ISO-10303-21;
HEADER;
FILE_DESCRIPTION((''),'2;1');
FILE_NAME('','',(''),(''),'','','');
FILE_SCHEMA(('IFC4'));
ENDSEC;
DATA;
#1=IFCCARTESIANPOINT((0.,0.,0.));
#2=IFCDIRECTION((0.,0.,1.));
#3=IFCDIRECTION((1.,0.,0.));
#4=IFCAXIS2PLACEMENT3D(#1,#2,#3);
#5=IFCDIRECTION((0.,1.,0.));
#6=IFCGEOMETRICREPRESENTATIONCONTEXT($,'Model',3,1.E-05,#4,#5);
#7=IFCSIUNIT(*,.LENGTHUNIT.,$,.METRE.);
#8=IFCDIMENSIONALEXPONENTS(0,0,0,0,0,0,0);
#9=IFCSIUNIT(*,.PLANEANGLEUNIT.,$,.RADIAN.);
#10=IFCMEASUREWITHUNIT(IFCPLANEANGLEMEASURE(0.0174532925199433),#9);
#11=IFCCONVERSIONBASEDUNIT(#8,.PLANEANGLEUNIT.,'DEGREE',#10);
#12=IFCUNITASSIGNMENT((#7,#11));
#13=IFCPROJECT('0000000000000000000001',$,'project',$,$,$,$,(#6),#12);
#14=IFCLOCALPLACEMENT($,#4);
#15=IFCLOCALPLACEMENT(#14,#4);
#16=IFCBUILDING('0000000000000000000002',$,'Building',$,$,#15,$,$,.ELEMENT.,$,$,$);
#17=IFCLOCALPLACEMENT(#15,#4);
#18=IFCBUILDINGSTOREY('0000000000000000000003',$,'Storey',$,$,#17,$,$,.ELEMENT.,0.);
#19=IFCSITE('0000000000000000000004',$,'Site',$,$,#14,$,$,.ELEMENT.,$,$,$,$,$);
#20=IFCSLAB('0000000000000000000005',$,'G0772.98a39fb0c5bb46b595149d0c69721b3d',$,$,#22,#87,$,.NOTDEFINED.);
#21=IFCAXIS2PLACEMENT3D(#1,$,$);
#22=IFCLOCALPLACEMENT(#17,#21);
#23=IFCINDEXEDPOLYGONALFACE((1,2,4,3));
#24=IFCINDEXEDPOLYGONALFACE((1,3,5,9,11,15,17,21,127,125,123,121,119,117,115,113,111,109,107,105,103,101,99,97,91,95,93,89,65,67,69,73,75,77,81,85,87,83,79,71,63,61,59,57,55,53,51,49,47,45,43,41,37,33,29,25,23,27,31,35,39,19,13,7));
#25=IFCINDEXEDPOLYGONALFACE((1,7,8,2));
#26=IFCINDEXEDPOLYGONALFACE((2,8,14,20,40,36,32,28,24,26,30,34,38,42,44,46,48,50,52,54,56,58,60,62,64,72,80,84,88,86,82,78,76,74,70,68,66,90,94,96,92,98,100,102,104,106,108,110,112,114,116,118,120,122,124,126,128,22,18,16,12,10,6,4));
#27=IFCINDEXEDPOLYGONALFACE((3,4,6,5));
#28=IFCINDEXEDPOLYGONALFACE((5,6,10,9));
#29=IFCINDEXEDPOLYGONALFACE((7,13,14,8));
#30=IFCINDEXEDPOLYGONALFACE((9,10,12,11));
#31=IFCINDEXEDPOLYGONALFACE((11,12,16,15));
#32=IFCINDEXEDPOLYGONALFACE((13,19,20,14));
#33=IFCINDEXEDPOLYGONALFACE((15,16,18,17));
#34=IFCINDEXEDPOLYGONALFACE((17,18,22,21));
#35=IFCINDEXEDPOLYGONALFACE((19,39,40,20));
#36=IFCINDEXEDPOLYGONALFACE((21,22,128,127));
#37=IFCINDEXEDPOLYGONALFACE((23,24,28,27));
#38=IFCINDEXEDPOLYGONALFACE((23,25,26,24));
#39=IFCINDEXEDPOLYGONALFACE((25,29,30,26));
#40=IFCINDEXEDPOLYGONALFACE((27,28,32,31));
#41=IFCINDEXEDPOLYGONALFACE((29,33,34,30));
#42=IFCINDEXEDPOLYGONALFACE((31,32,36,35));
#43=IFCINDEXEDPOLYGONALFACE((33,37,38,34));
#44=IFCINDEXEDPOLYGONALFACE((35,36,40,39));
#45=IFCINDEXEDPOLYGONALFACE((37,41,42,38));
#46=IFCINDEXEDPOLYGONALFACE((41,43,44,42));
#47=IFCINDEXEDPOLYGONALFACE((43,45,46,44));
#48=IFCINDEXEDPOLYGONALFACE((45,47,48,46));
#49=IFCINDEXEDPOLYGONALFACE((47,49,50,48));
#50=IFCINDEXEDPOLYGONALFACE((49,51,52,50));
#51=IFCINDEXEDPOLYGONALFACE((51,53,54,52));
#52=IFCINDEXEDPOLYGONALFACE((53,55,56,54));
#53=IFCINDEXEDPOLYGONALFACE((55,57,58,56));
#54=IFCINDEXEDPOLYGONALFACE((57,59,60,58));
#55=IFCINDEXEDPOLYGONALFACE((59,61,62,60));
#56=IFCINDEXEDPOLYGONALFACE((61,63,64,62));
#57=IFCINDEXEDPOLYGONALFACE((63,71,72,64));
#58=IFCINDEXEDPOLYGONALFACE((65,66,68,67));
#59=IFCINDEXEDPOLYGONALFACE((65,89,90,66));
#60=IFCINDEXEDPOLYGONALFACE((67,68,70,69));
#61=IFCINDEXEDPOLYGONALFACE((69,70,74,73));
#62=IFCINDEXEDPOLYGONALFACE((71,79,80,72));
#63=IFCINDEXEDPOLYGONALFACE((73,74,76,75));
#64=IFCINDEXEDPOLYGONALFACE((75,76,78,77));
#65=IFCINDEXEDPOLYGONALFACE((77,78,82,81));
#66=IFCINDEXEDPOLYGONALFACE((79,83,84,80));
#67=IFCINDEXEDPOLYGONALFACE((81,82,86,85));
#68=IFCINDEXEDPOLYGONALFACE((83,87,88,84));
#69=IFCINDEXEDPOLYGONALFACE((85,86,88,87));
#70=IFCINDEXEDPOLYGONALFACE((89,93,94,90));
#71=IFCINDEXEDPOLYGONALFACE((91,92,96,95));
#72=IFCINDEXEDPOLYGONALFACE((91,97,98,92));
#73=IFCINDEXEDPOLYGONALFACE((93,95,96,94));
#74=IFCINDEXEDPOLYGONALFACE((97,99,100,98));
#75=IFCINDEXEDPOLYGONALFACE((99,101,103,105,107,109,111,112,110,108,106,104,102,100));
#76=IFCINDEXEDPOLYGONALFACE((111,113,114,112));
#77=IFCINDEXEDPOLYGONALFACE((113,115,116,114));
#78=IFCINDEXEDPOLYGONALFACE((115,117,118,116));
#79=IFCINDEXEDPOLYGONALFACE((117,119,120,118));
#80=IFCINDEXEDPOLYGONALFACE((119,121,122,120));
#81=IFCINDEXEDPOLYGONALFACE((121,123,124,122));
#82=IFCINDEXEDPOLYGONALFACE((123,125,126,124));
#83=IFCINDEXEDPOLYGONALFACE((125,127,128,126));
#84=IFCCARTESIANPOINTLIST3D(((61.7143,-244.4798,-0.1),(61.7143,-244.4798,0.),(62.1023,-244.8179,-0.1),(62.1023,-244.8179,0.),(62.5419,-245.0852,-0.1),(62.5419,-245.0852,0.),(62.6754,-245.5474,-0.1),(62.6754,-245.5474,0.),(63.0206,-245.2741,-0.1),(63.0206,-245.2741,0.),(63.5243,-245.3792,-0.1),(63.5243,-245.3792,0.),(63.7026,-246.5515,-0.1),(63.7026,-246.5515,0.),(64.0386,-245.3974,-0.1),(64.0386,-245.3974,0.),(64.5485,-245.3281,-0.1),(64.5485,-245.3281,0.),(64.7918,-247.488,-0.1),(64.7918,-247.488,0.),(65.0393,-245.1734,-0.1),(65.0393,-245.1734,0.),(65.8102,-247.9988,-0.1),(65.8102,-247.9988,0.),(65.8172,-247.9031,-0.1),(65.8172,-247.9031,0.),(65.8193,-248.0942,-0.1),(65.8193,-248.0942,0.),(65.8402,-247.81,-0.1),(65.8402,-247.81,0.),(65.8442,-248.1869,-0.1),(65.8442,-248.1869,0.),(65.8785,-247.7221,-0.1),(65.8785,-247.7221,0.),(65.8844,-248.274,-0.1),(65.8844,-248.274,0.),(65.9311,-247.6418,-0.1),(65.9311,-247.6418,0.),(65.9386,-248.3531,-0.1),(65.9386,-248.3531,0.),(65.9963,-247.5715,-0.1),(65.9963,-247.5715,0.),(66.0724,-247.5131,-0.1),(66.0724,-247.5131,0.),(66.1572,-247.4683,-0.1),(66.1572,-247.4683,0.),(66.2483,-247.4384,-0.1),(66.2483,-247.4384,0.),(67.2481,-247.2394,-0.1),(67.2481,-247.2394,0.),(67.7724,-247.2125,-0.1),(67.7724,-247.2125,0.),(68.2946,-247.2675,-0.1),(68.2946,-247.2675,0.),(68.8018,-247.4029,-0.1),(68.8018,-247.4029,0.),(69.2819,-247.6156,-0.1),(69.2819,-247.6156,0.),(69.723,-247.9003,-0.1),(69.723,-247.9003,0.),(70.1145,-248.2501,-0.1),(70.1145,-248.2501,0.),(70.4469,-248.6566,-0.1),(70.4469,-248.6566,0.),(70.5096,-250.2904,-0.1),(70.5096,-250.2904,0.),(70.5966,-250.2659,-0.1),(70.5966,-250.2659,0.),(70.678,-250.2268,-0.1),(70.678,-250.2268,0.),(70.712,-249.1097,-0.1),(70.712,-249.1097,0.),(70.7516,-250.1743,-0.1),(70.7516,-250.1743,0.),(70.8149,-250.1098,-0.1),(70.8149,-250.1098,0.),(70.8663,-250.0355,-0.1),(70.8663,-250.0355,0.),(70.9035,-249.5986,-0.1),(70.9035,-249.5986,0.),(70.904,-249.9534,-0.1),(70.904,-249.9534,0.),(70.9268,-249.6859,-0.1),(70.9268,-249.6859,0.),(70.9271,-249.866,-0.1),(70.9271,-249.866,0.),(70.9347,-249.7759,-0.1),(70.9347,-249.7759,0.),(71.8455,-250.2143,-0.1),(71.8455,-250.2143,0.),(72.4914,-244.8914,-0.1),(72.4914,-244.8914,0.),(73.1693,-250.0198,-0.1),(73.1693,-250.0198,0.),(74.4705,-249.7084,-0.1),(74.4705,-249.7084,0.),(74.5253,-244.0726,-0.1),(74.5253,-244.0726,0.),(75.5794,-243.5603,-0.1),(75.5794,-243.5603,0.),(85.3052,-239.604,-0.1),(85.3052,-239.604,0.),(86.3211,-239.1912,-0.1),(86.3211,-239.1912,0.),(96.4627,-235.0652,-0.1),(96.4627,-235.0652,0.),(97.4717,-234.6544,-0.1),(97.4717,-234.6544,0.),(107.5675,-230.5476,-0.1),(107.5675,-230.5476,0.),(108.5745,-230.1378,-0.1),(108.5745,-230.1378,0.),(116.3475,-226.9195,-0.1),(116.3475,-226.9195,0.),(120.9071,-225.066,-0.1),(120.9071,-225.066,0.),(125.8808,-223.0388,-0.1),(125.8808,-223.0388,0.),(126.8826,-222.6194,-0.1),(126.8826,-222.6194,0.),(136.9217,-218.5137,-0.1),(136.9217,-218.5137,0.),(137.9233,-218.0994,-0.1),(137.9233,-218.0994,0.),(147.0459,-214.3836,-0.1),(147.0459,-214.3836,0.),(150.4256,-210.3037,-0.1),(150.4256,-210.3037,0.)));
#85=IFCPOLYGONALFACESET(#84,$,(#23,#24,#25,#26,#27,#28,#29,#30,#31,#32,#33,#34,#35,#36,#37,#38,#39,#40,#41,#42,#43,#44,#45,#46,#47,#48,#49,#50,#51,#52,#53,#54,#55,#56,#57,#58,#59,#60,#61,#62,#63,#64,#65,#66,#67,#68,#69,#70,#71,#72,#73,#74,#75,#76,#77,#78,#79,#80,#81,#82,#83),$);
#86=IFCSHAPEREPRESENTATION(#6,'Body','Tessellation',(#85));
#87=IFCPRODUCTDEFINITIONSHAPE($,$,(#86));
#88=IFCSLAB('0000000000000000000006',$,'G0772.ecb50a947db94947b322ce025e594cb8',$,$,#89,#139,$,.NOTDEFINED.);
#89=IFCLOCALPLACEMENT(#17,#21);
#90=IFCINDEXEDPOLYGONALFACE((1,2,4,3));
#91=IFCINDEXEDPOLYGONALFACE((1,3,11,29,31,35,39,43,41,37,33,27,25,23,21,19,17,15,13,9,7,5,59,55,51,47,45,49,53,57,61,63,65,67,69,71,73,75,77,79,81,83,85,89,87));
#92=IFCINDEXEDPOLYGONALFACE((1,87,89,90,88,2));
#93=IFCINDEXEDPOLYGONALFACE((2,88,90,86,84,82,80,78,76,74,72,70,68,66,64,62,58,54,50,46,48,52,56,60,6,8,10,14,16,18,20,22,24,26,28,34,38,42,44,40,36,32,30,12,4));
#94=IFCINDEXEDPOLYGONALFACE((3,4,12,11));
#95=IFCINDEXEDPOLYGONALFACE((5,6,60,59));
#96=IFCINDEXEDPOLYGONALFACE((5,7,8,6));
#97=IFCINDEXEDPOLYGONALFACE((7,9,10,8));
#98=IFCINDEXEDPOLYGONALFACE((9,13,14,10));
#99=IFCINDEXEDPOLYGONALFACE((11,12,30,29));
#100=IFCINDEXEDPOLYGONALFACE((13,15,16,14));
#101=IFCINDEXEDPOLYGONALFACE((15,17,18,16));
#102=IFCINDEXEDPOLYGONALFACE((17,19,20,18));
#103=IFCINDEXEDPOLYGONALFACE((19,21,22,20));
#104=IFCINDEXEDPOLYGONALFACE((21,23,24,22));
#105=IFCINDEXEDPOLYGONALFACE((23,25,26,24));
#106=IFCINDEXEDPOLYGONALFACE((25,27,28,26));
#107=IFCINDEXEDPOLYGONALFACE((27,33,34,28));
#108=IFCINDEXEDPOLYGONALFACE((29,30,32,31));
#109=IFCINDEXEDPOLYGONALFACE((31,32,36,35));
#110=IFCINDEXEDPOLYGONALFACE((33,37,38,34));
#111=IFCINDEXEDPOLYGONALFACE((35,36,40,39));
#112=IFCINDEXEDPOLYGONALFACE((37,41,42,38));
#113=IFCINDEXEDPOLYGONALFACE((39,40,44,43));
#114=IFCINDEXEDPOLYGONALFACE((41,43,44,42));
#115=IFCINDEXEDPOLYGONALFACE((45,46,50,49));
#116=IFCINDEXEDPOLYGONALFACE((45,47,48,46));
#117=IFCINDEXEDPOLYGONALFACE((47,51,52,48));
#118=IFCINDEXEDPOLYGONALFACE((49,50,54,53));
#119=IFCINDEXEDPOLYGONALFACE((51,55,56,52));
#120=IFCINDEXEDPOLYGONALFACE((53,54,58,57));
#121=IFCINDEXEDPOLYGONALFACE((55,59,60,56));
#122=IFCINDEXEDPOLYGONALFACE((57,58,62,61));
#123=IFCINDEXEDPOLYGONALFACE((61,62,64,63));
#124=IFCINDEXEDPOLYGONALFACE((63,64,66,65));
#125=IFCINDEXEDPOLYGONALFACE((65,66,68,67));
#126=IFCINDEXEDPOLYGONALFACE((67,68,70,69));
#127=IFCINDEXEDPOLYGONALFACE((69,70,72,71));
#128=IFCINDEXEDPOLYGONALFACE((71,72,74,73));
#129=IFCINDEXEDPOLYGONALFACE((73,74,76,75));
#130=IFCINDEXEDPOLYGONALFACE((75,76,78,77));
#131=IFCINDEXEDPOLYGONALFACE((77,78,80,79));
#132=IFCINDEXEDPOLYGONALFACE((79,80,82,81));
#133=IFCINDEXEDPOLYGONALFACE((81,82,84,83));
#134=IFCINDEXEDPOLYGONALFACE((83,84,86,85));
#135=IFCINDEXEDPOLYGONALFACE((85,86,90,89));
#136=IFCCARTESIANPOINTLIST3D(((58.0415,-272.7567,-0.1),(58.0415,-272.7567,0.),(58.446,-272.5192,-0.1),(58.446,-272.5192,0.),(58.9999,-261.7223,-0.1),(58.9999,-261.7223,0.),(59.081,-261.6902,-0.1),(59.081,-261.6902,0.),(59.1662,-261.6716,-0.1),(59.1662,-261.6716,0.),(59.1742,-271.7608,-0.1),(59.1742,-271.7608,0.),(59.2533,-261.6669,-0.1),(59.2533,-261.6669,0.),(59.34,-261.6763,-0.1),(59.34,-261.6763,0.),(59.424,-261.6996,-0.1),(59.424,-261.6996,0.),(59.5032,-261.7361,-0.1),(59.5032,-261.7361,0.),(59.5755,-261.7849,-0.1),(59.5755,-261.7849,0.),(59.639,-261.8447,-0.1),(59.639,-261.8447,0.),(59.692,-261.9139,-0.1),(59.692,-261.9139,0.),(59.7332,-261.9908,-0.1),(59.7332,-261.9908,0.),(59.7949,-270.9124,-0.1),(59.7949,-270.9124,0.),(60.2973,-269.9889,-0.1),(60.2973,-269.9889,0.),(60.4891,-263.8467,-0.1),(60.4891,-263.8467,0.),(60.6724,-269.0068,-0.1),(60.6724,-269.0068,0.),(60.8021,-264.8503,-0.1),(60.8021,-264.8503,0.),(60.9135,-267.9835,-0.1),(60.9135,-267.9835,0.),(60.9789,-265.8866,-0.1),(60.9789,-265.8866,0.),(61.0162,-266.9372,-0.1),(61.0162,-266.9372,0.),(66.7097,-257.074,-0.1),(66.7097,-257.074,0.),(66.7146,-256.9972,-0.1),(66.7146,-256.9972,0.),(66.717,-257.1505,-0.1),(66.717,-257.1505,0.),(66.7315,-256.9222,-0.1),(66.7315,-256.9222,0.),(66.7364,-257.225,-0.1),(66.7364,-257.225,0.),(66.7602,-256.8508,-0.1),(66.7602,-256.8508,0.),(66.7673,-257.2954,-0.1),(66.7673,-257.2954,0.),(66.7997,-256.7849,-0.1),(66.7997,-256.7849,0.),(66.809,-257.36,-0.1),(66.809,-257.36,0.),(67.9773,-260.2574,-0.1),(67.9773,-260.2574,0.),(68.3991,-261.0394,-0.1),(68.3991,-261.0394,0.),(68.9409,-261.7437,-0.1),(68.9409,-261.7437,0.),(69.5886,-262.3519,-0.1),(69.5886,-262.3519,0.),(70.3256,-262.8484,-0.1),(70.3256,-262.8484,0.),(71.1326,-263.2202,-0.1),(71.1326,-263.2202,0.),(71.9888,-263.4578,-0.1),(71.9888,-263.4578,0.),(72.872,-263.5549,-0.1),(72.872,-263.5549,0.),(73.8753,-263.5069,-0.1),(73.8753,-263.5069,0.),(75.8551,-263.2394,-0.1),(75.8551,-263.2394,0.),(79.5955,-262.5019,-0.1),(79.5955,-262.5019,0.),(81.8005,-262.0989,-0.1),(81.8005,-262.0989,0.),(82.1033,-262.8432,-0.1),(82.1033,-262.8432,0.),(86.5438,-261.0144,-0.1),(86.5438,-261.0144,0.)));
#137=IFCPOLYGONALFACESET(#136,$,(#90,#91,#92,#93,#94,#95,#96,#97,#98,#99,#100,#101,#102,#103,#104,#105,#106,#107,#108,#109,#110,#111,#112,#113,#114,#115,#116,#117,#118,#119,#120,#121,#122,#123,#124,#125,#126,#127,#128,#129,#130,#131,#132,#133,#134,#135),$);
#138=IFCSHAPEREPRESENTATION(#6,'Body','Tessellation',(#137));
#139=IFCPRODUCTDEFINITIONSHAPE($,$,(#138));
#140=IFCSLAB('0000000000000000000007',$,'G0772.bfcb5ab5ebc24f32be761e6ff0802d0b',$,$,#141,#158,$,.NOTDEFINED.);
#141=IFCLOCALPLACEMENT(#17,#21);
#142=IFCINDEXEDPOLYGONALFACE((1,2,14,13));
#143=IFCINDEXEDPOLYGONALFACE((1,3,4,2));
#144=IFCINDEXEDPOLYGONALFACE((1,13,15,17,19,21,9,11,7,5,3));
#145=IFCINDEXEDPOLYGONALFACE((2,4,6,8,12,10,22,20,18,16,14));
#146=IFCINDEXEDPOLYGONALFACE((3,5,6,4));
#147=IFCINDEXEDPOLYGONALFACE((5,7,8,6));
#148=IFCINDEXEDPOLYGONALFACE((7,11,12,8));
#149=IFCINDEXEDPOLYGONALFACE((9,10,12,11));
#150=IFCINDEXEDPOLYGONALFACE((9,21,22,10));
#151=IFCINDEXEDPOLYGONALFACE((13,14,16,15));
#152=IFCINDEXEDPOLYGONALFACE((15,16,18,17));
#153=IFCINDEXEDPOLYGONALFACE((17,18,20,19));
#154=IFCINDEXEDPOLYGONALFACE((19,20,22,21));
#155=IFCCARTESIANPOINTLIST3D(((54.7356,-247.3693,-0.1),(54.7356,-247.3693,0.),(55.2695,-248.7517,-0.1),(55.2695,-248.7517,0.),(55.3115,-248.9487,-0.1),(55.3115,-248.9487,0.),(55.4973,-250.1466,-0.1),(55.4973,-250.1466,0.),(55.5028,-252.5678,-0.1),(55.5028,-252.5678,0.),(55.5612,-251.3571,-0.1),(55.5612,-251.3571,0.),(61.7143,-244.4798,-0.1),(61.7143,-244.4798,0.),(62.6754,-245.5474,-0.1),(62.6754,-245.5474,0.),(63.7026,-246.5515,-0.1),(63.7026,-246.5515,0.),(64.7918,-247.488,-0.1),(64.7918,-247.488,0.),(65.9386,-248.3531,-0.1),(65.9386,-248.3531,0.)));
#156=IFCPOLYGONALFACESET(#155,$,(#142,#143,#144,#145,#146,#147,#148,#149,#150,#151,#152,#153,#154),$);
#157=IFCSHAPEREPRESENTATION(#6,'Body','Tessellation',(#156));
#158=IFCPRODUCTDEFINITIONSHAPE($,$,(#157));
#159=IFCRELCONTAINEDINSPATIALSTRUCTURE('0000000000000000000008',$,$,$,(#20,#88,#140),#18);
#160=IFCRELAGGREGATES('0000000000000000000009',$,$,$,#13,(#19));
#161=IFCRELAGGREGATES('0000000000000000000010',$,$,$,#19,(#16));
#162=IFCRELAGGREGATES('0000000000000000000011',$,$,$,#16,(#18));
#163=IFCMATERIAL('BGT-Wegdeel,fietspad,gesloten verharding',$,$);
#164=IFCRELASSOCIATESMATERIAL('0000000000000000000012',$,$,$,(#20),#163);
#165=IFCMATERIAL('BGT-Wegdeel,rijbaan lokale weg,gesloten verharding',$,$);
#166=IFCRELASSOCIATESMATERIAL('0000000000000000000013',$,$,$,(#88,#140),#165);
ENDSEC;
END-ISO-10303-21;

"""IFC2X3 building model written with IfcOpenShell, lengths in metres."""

from ifc_helpers import new_model, entity, si_unit, converted_unit, direction, frame, origin_with_axes, place, context, project, spatial, polyline, outline, extrude, material, element, save


model = new_model("IFC2X3")

# Units and contexts
model_context = context("Model", 3, precision=1e-05, world=origin_with_axes(), true_north=direction((0.0, 1.0, 0.0)))
ifc_project = project(units=[si_unit("LENGTHUNIT", "METRE"), converted_unit("PLANEANGLEUNIT", "DEGREE", entity("IfcPlaneAngleMeasure", 0.0174532925199433), si_unit("PLANEANGLEUNIT", "RADIAN"), dimensions=[0, 0, 0, 0, 0, 0, 0])], contexts=[model_context])

# Site, building, storey
site_placement = place(None, origin_with_axes())
site = spatial("IfcSite", under=ifc_project, at=site_placement, Name="Site", CompositionType="ELEMENT")
building_placement = place(site_placement, origin_with_axes())
building = spatial("IfcBuilding", under=site, at=building_placement, Name="Building", CompositionType="ELEMENT")
storey_placement = place(building_placement, origin_with_axes())
storey = spatial("IfcBuildingStorey", under=building, at=storey_placement, Name="Storey", CompositionType="ELEMENT", Elevation=0.0)

# Slabs
ifc_material_1 = material(Name="BGT-Wegdeel,rijbaan lokale weg,gesloten verharding")
ifc_material_2 = material(Name="BGT-Wegdeel,fietspad,gesloten verharding")
slab_1_placement = place(storey_placement, frame((0.0, 0.0, -0.1), z_axis=(0.0, 0.0, 1.0), x_axis=(1.0, 0.0, 0.0)))
element("IfcSlab", 1, at=slab_1_placement, inside=storey, material=ifc_material_2, Name="G0772.98a39fb0c5bb46b595149d0c69721b3d", PredefinedType="NOTDEFINED", context=model_context, shape_type="SweptSolid", body=[
    extrude(outline(polyline([(137.9233, -218.0994), (136.9217, -218.5137), (126.8826, -222.6194), (125.8808, -223.0388), (120.9071, -225.066), (116.3475, -226.9195), (108.5745, -230.1378), (107.5675, -230.5476), (97.4717, -234.6544), (96.4627, -235.0652), (86.3211, -239.1912), (85.3052, -239.604), (75.5794, -243.5603), (74.5253, -244.0726), (72.4914, -244.8914), (74.4705, -249.7084), (73.1693, -250.0198), (71.8455, -250.2143), (70.5096, -250.2904), (70.5966, -250.2659), (70.678, -250.2268), (70.7516, -250.1743), (70.8149, -250.1098), (70.8663, -250.0355), (70.904, -249.9534), (70.9271, -249.866), (70.9347, -249.7759), (70.9268, -249.6859), (70.9035, -249.5986), (70.712, -249.1097), (70.4469, -248.6566), (70.1145, -248.2501), (69.723, -247.9003), (69.2819, -247.6156), (68.8018, -247.4029), (68.2946, -247.2675), (67.7724, -247.2125), (67.2481, -247.2394), (66.2483, -247.4384), (66.1572, -247.4683), (66.0724, -247.5131), (65.9963, -247.5715), (65.9311, -247.6418), (65.8785, -247.7221), (65.8402, -247.81), (65.8172, -247.9031), (65.8102, -247.9988), (65.8193, -248.0942), (65.8442, -248.1869), (65.8844, -248.274), (65.9386, -248.3531), (64.7918, -247.488), (63.7026, -246.5515), (62.6754, -245.5474), (61.7143, -244.4798), (62.1023, -244.8179), (62.5419, -245.0852), (63.0206, -245.2741), (63.5243, -245.3792), (64.0386, -245.3974), (64.5485, -245.3281), (65.0393, -245.1734), (150.4256, -210.3037), (147.0459, -214.3836), (137.9233, -218.0994)])), origin_with_axes(), (0.0, 0.0, 1.0), 0.1),
])
slab_2_placement = place(storey_placement, frame((0.0, 0.0, -0.1), z_axis=(0.0, 0.0, 1.0), x_axis=(1.0, 0.0, 0.0)))
element("IfcSlab", 2, at=slab_2_placement, inside=storey, material=ifc_material_1, Name="G0772.ecb50a947db94947b322ce025e594cb8", PredefinedType="NOTDEFINED", context=model_context, shape_type="SweptSolid", body=[
    extrude(outline(polyline([(67.9773, -260.2574), (68.3991, -261.0394), (68.9409, -261.7437), (69.5886, -262.3519), (70.3256, -262.8484), (71.1326, -263.2202), (71.9888, -263.4578), (72.872, -263.5549), (73.8753, -263.5069), (75.8551, -263.2394), (79.5955, -262.5019), (81.8005, -262.0989), (86.5438, -261.0144), (82.1033, -262.8432), (58.0415, -272.7567), (58.446, -272.5192), (59.1742, -271.7608), (59.7949, -270.9124), (60.2973, -269.9889), (60.6724, -269.0068), (60.9135, -267.9835), (61.0162, -266.9372), (60.9789, -265.8866), (60.8021, -264.8503), (60.4891, -263.8467), (59.7332, -261.9908), (59.692, -261.9139), (59.639, -261.8447), (59.5755, -261.7849), (59.5032, -261.7361), (59.424, -261.6996), (59.34, -261.6763), (59.2533, -261.6669), (59.1662, -261.6716), (59.081, -261.6902), (58.9999, -261.7223), (66.7997, -256.7849), (66.7602, -256.8508), (66.7315, -256.9222), (66.7146, -256.9972), (66.7097, -257.074), (66.717, -257.1505), (66.7364, -257.225), (66.7673, -257.2954), (66.809, -257.36), (67.9773, -260.2574)])), origin_with_axes(), (0.0, 0.0, 1.0), 0.1),
])
slab_3_placement = place(storey_placement, frame((0.0, 0.0, -0.1), z_axis=(0.0, 0.0, 1.0), x_axis=(1.0, 0.0, 0.0)))
element("IfcSlab", 3, at=slab_3_placement, inside=storey, material=ifc_material_1, Name="G0772.bfcb5ab5ebc24f32be761e6ff0802d0b", PredefinedType="NOTDEFINED", context=model_context, shape_type="SweptSolid", body=[
    extrude(outline(polyline([(62.6754, -245.5474), (63.7026, -246.5515), (64.7918, -247.488), (65.9386, -248.3531), (55.5028, -252.5678), (55.5612, -251.3571), (55.4973, -250.1466), (55.3115, -248.9487), (55.2695, -248.7517), (54.7356, -247.3693), (61.7143, -244.4798), (62.6754, -245.5474)])), origin_with_axes(), (0.0, 0.0, 1.0), 0.1),
])

save(model, "model.ifc")
